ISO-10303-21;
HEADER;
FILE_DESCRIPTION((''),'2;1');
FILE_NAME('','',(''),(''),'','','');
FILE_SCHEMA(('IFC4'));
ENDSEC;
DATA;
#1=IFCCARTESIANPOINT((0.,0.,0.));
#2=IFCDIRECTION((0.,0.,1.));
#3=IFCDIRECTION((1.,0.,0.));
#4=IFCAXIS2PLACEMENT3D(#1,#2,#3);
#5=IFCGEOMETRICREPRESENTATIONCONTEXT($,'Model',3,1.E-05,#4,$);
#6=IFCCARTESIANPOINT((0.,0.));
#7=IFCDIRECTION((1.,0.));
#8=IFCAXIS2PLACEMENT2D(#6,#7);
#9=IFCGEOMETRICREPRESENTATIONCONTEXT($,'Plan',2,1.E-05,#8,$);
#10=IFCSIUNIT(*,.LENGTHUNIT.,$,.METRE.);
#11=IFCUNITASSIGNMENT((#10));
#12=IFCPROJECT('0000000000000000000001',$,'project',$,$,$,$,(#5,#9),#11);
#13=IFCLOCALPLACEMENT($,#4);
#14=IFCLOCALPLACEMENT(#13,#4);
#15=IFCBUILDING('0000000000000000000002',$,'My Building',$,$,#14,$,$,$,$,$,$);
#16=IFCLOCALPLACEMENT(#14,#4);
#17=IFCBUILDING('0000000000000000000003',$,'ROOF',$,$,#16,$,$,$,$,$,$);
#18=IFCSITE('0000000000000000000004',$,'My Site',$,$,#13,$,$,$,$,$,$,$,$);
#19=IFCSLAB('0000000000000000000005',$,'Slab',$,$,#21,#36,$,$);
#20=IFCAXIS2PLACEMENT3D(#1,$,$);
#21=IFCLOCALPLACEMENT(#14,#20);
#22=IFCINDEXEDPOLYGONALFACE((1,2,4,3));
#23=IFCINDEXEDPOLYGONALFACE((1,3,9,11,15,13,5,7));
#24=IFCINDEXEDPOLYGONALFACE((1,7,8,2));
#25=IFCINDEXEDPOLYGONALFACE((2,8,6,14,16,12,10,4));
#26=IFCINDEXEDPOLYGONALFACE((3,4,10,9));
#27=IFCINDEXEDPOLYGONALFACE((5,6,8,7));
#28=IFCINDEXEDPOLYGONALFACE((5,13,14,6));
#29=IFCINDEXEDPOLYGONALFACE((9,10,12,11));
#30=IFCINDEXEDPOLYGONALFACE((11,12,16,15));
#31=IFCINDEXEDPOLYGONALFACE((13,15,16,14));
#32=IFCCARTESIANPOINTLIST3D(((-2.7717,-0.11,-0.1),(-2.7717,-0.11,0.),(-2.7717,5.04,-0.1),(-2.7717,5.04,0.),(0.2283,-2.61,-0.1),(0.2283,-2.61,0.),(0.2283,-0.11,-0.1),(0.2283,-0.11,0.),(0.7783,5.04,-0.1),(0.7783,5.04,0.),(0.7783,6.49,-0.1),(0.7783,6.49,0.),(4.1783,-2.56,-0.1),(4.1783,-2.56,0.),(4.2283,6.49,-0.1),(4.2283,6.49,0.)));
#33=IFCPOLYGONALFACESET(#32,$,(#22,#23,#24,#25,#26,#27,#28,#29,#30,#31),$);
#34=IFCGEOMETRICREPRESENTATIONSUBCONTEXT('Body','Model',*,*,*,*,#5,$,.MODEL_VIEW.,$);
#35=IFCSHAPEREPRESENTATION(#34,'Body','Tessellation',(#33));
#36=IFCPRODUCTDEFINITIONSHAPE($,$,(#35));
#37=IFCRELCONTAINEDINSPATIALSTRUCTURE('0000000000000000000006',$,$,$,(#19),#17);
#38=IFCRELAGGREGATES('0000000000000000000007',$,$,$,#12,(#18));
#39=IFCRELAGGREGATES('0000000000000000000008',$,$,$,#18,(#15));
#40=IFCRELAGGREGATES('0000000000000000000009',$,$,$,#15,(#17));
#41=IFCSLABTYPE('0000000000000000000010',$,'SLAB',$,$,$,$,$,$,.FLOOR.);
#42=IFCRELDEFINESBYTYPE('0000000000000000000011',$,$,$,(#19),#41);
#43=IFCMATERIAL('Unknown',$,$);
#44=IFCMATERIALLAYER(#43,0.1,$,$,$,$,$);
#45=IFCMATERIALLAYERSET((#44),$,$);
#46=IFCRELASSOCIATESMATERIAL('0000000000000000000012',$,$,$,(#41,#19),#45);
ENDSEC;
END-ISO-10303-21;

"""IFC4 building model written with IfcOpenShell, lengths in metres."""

from ifc_helpers import new_model, si_unit, frame, origin_with_axes, origin_2d_with_axis, place, context, subcontext, project, spatial, indexed_curve, outline, extrude, material, layer, layer_set, layer_usage, type_object, element, save


model = new_model("IFC4")

# Units and contexts
model_context = context("Model", 3, precision=1e-05, world=origin_with_axes())
plan_context = context("Plan", 2, precision=1e-05, world=origin_2d_with_axis())
body_context = subcontext(model_context, "Body", "Model", "MODEL_VIEW")
ifc_project = project(units=[si_unit("LENGTHUNIT", "METRE")], contexts=[model_context, plan_context])

# Site, buildings
site_placement = place(None, origin_with_axes())
site = spatial("IfcSite", under=ifc_project, at=site_placement, Name="My Site")
building_1_placement = place(site_placement, origin_with_axes())
building_1 = spatial("IfcBuilding", under=site, at=building_1_placement, Name="My Building")
building_2_placement = place(building_1_placement, origin_with_axes())
building_2 = spatial("IfcBuilding", under=building_1, at=building_2_placement, Name="ROOF")

# Slab
ifc_material = material(Name="Unknown")
ifc_layer = layer(ifc_material, 0.1)
ifc_layer_set = layer_set([ifc_layer])
ifc_layer_usage = layer_usage(ifc_layer_set, "AXIS3", "POSITIVE", -0.1)
slab_type = type_object("IfcSlabType", Name="SLAB", PredefinedType="FLOOR", material=ifc_layer_set)
slab_placement = place(building_2_placement, frame((4.2283, 6.49, 0.0), z_axis=(0.0, 0.0, 1.0), x_axis=(1.0, 0.0, 0.0)))
element("IfcSlab", 1, at=slab_placement, inside=building_2, type_object=slab_type, material=ifc_layer_usage, Name="Slab", context=body_context, shape_type="SweptSolid", body=[
    extrude(outline(indexed_curve([(0.0, 0.0), (-3.45, 0.0), (-3.45, -1.45), (-7.0, -1.45), (-7.0, -6.6), (-4.0, -6.6), (-4.0, -9.1), (-0.05, -9.05), (0.0, 0.0)])), frame((0.0, 0.0, -0.1), z_axis=(0.0, 0.0, 1.0), x_axis=(1.0, 0.0, 0.0)), (0.0, 0.0, 1.0), 0.1),
])

save(model, "model.ifc")
